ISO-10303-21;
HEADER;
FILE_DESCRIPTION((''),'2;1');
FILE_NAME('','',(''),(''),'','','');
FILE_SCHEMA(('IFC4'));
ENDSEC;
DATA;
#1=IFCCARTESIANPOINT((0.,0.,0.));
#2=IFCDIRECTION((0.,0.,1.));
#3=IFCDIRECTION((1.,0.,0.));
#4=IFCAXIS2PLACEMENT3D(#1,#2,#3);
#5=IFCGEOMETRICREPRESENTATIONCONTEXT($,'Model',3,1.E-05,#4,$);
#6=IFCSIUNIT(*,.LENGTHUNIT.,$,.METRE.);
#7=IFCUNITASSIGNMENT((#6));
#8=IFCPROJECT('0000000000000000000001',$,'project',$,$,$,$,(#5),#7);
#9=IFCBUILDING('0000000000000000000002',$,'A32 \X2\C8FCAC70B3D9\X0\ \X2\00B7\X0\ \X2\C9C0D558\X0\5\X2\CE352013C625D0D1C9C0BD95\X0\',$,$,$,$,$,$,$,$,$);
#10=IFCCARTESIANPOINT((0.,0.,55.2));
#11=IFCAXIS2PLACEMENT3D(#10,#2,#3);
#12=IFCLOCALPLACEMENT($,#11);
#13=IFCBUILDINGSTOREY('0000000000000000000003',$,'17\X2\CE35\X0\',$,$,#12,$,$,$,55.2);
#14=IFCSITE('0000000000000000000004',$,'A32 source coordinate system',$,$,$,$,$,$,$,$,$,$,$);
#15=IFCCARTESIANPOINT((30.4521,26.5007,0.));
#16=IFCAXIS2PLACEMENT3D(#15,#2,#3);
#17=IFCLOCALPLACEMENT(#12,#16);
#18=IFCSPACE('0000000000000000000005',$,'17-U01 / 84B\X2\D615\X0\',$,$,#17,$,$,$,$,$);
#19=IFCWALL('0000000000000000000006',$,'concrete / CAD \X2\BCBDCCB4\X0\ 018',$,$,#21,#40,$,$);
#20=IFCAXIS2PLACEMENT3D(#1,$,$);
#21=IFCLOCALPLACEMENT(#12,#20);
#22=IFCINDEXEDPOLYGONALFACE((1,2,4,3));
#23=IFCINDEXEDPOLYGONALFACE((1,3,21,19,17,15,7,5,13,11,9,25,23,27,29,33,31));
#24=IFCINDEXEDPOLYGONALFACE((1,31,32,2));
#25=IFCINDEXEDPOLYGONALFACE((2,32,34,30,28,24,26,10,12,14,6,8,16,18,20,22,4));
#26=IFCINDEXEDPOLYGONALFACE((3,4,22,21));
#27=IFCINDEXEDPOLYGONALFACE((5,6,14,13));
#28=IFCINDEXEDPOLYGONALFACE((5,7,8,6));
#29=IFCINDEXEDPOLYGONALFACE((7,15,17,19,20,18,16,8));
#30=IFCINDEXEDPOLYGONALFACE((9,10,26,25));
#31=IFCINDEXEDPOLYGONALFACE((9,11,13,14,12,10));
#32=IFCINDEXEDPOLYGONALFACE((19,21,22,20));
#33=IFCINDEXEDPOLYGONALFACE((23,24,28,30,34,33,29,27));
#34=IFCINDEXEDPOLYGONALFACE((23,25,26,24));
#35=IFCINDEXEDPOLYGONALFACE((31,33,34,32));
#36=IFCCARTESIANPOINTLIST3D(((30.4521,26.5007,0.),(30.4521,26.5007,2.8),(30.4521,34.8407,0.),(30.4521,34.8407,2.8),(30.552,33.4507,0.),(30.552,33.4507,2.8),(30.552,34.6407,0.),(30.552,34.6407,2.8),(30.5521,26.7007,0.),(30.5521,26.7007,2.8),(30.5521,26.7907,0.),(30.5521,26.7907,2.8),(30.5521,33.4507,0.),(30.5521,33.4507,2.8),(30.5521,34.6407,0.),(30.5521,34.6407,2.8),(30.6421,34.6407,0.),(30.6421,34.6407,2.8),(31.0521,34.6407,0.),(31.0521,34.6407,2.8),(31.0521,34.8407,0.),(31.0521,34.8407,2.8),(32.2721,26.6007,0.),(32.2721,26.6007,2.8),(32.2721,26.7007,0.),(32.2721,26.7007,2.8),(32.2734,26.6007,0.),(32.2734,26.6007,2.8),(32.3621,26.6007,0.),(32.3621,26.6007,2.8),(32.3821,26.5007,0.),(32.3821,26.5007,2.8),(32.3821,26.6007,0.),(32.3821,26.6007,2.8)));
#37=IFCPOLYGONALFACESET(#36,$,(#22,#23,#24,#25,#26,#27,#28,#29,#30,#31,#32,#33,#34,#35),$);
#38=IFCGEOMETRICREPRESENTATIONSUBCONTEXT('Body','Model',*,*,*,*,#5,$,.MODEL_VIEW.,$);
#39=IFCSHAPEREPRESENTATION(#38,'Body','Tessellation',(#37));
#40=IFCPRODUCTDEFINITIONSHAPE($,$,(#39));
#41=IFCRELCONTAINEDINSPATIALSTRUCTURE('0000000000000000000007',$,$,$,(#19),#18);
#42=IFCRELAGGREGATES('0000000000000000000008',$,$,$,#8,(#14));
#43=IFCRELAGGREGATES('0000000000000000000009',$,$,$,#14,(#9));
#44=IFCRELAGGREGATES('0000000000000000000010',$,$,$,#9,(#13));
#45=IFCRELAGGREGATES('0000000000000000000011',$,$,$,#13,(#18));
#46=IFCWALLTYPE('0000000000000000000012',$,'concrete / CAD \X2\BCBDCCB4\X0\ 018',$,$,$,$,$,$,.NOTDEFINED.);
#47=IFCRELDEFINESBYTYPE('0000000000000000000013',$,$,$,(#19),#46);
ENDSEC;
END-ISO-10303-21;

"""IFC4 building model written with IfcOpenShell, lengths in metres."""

from ifc_helpers import new_model, si_unit, frame, origin, origin_with_axes, place, context, subcontext, project, spatial, polyline, outline, extrude, source, transform, mapped, type_object, type_shapes, element, save


model = new_model("IFC4")

# Units and contexts
model_context = context("Model", 3, precision=1e-05, world=origin_with_axes())
body_context = subcontext(model_context, "Body", "Model", "MODEL_VIEW")
ifc_project = project(units=[si_unit("LENGTHUNIT", "METRE")], contexts=[model_context])

# Site, building, storey, space
site = spatial("IfcSite", under=ifc_project, Name="A32 source coordinate system")
building = spatial("IfcBuilding", under=site, Name="A32 주거동 · 지하5층–옥탑지붕")
storey_placement = place(None, frame((0.0, 0.0, 55.2), z_axis=(0.0, 0.0, 1.0), x_axis=(1.0, 0.0, 0.0)))
storey = spatial("IfcBuildingStorey", under=building, at=storey_placement, Name="17층", Elevation=55.2)
space_1_placement = place(storey_placement, frame((30.4521, 26.5007, 0.0), z_axis=(0.0, 0.0, 1.0), x_axis=(1.0, 0.0, 0.0)))
space_1 = spatial("IfcSpace", under=storey, at=space_1_placement, Name="17-U01 / 84B형")

# Wall
wall_type_1 = type_object("IfcWallType", Name="concrete / CAD 벽체 018", PredefinedType="NOTDEFINED")
shared_shape_1 = source(origin(), body_context, "Body", "SweptSolid", [
    extrude(outline(polyline([(0.6, 8.34), (0.6, 8.14), (0.19, 8.14), (0.1, 8.14), (0.0999, 8.14), (0.0999, 6.95), (0.1, 6.95), (0.1, 0.29), (0.1, 0.2), (1.82, 0.2), (1.82, 0.1), (1.8213, 0.1), (1.91, 0.1), (1.93, 0.1), (1.93, 0.0), (0.0, 0.0), (0.0, 8.34), (-0.35, 8.34), (-0.35, 8.34), (0.6, 8.34)])), origin(), (0.0, 0.0, 1.0), 2.8),
])
type_shapes(wall_type_1, [shared_shape_1])
wall_1_placement = place(space_1_placement, origin_with_axes())
element("IfcWall", 1, at=wall_1_placement, inside=space_1, type_object=wall_type_1, Name="concrete / CAD 벽체 018", context=body_context, shape_type="MappedRepresentation", body=[
    mapped(shared_shape_1, transform((0.0, 0.0, 0.0), scale=1.0)),
])

save(model, "model.ifc")
